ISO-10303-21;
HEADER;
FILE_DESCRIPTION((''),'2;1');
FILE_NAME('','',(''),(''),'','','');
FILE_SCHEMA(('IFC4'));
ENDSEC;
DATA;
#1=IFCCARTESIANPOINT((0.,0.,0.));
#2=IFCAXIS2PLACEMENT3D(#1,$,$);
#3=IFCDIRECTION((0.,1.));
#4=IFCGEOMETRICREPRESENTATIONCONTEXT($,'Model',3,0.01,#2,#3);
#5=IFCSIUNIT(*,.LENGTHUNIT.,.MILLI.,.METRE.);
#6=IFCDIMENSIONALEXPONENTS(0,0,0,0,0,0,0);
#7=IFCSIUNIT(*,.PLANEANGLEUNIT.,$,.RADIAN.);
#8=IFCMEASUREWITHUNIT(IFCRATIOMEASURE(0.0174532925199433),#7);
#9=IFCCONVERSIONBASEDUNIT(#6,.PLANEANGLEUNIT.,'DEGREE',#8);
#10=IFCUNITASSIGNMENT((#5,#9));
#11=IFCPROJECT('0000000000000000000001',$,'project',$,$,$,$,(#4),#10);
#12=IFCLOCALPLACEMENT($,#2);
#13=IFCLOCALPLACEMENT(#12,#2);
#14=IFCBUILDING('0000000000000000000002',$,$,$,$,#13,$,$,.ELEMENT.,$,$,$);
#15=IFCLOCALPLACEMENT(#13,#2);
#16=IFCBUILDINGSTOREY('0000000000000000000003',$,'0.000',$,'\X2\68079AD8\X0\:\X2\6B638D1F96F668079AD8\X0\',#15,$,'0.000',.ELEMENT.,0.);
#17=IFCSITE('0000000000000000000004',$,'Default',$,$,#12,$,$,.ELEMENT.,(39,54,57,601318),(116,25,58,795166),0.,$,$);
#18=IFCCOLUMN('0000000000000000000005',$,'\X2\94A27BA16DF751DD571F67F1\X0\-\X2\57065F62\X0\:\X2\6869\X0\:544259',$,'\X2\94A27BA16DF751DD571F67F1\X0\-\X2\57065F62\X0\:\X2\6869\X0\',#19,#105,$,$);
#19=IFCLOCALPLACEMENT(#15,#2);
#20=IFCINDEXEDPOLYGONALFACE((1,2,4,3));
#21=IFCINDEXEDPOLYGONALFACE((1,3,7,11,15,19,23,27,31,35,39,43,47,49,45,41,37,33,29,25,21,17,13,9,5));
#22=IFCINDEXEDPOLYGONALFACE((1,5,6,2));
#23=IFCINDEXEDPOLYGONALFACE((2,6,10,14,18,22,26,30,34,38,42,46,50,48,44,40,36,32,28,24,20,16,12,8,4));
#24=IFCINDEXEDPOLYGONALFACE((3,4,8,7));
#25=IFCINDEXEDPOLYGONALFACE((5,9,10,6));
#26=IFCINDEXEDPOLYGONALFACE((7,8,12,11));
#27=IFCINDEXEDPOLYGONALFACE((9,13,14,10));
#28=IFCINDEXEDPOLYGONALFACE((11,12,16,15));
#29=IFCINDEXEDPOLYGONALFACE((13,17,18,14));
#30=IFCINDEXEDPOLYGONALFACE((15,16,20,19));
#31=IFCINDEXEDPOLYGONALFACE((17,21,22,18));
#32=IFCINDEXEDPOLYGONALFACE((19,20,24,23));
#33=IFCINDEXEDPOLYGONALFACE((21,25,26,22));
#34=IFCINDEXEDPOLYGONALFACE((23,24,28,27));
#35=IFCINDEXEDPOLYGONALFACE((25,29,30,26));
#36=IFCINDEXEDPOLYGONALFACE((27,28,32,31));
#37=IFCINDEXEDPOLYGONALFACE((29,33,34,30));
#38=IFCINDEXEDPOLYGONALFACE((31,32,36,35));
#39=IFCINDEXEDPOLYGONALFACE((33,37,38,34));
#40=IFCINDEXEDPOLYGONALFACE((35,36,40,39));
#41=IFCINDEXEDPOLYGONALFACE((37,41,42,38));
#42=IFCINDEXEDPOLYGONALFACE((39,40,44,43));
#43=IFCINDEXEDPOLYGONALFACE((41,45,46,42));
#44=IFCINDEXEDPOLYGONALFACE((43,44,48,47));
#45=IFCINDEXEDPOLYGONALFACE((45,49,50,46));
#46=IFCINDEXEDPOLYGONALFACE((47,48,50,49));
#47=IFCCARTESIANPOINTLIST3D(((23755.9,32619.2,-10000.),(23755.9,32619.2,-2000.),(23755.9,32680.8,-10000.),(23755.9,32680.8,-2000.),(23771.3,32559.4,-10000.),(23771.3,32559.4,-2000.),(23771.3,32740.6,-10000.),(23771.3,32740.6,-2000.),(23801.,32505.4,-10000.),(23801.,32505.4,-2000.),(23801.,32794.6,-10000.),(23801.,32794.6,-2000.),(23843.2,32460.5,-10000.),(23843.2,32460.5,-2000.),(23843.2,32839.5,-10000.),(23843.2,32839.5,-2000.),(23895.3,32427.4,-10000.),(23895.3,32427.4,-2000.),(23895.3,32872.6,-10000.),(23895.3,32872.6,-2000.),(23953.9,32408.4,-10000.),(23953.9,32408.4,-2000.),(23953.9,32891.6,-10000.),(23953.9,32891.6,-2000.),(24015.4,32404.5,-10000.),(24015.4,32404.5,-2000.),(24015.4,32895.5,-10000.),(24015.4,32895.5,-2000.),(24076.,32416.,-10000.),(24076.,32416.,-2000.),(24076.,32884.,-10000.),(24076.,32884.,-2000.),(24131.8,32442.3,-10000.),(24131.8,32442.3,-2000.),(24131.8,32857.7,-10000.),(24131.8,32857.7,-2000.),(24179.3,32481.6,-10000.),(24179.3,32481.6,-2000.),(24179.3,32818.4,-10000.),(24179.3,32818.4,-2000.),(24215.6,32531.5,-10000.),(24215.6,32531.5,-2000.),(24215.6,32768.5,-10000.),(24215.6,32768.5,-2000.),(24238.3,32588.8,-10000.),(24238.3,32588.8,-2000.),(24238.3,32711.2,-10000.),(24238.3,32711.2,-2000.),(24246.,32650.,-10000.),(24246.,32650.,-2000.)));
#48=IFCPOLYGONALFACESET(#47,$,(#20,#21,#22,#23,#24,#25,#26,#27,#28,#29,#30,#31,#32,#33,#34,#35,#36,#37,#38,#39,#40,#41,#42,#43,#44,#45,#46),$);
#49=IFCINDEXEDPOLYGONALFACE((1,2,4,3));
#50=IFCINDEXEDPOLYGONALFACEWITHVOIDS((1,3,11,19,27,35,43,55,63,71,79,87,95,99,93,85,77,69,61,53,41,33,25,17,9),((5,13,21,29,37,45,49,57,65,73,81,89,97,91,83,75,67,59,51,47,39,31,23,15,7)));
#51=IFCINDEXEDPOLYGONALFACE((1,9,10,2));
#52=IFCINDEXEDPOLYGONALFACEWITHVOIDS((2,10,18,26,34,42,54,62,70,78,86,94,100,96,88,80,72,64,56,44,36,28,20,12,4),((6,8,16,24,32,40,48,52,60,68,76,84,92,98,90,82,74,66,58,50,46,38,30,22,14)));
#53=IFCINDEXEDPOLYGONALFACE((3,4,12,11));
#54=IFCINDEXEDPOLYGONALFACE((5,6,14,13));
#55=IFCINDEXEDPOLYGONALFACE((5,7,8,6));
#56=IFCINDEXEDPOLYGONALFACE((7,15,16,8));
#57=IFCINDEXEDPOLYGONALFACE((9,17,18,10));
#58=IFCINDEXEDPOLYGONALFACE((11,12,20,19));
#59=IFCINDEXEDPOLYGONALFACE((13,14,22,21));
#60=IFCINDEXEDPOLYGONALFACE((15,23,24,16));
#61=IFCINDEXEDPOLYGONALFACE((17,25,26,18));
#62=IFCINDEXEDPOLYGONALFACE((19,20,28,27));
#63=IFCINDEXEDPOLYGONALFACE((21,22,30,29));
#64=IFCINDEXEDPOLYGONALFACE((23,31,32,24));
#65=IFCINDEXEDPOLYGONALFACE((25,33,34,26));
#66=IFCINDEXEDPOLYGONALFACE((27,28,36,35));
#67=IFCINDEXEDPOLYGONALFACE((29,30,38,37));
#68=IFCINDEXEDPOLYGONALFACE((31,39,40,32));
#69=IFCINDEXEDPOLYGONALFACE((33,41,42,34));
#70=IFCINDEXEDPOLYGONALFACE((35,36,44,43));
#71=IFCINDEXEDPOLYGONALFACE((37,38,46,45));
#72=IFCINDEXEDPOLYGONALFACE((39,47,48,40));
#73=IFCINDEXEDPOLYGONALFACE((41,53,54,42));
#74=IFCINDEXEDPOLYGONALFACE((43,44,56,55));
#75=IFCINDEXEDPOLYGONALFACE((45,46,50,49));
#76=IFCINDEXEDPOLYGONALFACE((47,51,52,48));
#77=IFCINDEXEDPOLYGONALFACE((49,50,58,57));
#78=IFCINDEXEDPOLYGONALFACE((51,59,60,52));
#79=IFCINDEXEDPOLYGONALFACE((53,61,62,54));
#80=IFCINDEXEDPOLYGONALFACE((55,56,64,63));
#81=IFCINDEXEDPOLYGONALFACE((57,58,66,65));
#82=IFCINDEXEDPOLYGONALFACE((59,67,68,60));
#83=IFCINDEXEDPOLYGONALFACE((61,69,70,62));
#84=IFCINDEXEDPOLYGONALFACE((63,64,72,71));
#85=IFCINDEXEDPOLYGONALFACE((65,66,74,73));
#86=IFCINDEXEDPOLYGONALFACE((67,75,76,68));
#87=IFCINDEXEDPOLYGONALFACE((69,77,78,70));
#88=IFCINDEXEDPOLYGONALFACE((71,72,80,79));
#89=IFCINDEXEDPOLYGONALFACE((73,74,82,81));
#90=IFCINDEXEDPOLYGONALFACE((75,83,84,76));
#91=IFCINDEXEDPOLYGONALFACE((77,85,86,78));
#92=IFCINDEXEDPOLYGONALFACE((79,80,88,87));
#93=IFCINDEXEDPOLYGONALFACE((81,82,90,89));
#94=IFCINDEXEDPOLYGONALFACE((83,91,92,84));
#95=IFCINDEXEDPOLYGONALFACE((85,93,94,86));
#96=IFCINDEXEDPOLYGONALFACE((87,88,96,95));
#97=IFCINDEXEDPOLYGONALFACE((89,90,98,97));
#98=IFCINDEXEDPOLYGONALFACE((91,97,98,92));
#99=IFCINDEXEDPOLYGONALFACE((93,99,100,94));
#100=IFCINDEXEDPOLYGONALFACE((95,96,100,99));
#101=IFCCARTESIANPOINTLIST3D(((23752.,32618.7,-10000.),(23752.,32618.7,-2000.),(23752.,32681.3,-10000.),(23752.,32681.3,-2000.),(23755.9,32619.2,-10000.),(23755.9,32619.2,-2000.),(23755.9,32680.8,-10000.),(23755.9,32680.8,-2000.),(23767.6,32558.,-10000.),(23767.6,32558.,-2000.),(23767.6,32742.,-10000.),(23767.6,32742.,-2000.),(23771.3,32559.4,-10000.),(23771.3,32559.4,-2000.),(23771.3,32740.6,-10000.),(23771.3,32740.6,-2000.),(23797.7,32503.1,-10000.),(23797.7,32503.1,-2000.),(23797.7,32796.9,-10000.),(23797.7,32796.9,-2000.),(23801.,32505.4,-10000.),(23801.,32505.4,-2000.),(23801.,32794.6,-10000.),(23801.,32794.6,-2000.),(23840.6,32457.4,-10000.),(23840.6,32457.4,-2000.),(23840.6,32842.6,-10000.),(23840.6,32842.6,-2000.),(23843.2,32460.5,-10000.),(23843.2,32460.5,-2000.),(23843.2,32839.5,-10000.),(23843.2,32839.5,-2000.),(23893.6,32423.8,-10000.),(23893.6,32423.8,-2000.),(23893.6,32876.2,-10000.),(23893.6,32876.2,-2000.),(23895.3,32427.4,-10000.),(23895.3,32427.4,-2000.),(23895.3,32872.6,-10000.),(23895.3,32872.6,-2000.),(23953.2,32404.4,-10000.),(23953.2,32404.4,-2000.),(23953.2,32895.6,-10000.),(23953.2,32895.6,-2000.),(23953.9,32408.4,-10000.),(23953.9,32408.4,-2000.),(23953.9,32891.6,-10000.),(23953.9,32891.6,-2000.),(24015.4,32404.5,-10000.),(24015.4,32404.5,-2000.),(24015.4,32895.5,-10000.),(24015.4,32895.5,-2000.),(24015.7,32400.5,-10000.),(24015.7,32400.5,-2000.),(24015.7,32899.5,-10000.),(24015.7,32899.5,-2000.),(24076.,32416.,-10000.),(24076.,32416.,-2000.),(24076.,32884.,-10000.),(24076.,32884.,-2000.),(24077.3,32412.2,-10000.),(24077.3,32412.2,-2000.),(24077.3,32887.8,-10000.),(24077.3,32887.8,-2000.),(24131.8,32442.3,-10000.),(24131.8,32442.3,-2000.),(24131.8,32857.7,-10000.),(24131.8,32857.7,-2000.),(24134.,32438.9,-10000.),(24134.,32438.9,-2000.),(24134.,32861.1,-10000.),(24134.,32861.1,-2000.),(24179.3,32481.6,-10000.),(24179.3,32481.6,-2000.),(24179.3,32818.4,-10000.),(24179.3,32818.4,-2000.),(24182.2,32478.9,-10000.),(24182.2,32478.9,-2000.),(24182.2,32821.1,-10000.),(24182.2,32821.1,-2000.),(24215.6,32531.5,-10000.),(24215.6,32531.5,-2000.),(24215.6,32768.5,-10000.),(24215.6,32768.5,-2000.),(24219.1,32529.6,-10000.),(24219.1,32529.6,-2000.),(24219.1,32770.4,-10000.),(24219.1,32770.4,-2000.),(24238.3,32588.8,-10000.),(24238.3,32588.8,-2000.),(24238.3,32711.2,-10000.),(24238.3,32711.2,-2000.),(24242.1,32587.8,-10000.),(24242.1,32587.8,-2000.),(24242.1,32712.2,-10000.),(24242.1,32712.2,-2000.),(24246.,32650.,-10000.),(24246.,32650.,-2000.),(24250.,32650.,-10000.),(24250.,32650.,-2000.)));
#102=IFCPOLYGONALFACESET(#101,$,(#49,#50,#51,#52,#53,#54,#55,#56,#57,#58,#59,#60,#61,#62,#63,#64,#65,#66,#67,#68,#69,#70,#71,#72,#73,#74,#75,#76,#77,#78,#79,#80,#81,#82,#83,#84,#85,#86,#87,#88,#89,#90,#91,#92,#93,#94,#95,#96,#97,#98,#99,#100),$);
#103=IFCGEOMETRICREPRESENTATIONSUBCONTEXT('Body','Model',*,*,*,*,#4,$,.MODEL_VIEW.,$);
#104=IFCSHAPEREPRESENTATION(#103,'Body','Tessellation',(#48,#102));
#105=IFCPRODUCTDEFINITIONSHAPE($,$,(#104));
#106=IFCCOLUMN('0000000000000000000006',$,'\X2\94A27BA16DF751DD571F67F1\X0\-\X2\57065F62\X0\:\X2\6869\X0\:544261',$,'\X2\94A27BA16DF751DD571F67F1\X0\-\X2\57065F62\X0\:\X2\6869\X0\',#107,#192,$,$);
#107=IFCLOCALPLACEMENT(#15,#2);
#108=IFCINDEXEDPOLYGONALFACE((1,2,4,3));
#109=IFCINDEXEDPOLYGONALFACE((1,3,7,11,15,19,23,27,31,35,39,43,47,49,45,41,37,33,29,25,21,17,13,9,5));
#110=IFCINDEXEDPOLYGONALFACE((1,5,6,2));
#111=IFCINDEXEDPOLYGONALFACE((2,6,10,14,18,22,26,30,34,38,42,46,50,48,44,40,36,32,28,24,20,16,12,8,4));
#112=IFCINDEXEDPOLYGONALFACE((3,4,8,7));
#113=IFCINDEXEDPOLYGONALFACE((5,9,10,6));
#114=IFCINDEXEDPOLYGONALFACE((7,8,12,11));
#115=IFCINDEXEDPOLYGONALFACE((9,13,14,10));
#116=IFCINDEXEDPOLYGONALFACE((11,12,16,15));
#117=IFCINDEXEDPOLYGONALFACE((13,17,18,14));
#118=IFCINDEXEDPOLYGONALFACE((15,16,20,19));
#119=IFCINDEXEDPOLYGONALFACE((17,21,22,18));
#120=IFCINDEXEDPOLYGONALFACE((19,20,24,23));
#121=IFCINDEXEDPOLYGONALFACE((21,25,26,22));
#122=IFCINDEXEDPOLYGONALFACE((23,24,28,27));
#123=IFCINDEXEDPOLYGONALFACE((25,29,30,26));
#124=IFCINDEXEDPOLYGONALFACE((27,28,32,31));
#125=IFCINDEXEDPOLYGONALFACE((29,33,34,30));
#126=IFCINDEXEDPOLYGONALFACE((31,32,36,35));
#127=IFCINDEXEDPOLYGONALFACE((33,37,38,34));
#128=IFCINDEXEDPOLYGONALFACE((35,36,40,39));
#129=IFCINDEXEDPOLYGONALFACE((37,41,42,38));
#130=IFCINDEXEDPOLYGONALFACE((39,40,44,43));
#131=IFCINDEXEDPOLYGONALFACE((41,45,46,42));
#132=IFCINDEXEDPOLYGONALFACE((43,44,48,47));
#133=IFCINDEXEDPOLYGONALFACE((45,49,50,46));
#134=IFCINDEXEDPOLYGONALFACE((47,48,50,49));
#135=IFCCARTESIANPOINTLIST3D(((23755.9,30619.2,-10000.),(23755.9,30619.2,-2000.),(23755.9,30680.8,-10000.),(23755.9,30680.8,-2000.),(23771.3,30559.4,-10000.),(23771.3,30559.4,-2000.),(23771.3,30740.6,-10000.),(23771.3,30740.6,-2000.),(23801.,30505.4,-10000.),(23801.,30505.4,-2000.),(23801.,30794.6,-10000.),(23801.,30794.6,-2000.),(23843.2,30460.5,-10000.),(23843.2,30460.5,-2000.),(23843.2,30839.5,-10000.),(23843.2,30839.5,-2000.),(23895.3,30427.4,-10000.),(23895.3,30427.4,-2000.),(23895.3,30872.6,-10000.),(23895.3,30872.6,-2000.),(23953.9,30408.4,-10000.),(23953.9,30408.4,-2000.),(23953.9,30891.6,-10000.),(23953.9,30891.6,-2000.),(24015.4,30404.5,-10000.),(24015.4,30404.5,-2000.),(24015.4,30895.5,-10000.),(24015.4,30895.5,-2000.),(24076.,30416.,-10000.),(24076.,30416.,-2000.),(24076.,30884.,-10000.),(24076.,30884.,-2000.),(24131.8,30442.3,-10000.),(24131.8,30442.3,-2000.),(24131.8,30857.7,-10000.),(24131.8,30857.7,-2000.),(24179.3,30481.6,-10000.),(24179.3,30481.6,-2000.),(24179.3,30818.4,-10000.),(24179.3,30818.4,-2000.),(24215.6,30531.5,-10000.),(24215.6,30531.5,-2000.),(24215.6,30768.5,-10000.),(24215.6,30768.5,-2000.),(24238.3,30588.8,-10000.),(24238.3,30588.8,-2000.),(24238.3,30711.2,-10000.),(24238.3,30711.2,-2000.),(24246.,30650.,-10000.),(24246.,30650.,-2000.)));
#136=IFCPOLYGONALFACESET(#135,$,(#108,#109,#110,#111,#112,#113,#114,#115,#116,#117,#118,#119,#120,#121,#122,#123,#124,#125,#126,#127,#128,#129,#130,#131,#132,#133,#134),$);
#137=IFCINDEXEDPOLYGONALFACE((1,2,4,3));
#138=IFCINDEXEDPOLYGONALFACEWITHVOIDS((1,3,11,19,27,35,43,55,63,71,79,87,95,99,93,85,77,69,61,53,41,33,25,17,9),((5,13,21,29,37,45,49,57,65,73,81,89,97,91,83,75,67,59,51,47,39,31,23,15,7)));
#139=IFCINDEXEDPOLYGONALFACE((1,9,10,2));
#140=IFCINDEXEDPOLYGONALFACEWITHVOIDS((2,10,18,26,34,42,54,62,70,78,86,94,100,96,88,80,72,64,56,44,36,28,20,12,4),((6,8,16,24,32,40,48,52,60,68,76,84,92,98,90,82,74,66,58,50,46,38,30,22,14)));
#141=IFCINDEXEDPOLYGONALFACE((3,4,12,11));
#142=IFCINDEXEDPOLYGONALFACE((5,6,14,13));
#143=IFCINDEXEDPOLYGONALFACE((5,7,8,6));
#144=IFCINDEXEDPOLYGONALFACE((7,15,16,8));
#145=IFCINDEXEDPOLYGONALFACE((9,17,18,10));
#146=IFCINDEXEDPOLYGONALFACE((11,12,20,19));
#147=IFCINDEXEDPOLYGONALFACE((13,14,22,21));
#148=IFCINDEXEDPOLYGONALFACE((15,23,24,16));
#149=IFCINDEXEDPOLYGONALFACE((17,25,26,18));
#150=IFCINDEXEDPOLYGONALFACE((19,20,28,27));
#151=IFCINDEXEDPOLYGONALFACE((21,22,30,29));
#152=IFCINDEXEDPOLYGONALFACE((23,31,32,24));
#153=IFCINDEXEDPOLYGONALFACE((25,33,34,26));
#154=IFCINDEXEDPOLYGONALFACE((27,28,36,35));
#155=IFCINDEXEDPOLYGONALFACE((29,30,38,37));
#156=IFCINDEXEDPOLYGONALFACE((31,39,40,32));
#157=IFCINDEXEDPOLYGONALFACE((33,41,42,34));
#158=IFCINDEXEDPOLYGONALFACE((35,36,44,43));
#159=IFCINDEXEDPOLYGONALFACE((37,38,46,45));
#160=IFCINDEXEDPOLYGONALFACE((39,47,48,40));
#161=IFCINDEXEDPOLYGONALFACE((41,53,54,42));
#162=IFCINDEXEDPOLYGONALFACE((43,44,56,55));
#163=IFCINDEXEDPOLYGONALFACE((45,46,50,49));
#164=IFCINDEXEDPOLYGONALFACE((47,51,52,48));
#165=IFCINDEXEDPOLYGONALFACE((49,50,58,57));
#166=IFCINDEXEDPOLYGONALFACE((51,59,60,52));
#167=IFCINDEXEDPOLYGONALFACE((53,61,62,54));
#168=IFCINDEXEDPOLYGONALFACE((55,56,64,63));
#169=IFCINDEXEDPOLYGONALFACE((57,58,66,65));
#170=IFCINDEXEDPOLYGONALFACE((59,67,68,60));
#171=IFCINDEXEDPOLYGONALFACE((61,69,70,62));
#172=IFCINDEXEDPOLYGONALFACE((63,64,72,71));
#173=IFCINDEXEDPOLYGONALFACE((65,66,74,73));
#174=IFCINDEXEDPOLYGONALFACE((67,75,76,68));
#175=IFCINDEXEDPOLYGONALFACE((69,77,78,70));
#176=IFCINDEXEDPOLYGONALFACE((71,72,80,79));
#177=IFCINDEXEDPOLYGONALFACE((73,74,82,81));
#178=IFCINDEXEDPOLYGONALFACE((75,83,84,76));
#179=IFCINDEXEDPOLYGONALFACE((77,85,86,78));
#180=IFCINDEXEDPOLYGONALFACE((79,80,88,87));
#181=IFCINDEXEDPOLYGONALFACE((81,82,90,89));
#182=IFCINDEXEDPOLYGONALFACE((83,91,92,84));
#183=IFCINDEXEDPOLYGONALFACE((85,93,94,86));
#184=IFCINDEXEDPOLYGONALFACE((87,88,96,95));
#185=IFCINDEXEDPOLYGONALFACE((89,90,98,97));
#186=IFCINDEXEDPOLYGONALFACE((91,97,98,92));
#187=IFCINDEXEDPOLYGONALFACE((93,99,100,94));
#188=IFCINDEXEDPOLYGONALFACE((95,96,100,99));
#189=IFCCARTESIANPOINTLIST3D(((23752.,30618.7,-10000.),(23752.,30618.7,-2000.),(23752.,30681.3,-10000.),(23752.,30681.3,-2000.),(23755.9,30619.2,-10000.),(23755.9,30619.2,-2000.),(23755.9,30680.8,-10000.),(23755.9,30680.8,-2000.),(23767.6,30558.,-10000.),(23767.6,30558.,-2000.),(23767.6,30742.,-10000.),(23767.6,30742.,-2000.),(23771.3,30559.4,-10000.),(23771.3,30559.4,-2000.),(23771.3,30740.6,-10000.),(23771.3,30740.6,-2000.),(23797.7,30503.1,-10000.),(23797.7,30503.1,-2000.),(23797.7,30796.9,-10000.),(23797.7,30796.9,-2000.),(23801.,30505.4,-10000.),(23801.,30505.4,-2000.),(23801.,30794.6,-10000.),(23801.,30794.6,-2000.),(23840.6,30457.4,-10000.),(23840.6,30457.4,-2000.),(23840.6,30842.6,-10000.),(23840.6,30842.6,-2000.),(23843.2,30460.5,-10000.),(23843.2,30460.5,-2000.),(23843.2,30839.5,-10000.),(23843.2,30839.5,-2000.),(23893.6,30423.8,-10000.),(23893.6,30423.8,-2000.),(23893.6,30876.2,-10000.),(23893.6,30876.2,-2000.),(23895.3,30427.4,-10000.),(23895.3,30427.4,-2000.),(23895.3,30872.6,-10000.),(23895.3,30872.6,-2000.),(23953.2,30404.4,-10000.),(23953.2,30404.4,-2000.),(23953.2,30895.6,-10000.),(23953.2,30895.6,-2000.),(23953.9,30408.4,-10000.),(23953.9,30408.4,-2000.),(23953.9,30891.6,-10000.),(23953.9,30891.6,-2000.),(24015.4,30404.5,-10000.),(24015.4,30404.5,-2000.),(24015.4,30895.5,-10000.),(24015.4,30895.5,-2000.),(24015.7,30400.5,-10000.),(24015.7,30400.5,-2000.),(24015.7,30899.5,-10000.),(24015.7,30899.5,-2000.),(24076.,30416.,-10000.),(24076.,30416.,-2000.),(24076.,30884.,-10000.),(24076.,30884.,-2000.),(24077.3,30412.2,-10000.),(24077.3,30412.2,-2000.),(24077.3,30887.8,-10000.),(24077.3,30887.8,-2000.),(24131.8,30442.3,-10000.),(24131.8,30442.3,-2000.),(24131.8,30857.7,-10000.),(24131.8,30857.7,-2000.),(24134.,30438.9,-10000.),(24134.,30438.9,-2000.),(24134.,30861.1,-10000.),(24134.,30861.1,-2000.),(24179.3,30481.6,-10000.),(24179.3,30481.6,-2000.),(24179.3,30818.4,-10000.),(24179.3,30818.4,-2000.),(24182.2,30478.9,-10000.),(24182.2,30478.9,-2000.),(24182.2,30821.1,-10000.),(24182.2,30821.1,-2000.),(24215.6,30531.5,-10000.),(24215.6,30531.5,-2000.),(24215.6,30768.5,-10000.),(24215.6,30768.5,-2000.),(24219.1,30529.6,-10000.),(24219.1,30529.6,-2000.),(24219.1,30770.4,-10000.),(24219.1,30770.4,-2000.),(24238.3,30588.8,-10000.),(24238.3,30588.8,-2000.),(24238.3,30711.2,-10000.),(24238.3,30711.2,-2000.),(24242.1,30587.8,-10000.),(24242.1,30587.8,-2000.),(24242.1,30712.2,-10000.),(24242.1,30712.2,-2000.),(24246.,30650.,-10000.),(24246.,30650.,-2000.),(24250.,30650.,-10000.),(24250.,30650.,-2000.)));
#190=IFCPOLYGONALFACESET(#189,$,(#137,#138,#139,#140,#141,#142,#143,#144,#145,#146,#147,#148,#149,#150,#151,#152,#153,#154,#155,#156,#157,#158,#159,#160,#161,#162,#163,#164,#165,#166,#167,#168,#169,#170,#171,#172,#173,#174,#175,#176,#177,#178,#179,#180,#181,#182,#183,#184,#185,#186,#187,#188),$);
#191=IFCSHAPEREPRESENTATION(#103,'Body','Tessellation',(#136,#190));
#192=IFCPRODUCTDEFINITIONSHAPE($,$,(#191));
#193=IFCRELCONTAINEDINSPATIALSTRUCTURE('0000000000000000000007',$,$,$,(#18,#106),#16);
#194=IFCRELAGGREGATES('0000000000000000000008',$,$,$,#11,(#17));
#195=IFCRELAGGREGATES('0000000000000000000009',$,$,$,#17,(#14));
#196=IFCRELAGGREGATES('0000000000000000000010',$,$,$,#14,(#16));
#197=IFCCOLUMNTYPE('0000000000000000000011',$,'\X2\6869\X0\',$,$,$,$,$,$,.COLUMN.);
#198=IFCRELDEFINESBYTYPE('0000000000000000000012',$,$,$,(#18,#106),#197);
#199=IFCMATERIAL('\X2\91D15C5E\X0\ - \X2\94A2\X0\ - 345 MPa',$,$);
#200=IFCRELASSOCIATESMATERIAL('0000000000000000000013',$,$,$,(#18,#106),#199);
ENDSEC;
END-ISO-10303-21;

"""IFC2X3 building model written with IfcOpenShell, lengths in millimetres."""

from ifc_helpers import new_model, entity, si_unit, converted_unit, direction, frame, frame_2d, origin, place, context, subcontext, project, spatial, circle, hollow_circle, extrude, source, transform, mapped, material, type_object, type_shapes, element, save


model = new_model("IFC2X3")

# Units and contexts
model_context = context("Model", 3, precision=0.01, world=origin(), true_north=direction((0.0, 1.0)))
body_context = subcontext(model_context, "Body", "Model", "MODEL_VIEW")
ifc_project = project(units=[si_unit("LENGTHUNIT", "METRE", prefix="MILLI"), converted_unit("PLANEANGLEUNIT", "DEGREE", entity("IfcRatioMeasure", 0.0174532925199433), si_unit("PLANEANGLEUNIT", "RADIAN"), dimensions=[0, 0, 0, 0, 0, 0, 0])], contexts=[model_context])

# Site, building, storey
site_placement = place(None, origin())
site = spatial("IfcSite", under=ifc_project, at=site_placement, Name="Default", CompositionType="ELEMENT", RefLatitude=(39, 54, 57, 601318), RefLongitude=(116, 25, 58, 795166), RefElevation=0.0)
building_placement = place(site_placement, origin())
building = spatial("IfcBuilding", under=site, at=building_placement, CompositionType="ELEMENT")
storey_placement = place(building_placement, origin())
storey = spatial("IfcBuildingStorey", under=building, at=storey_placement, Name="0.000", ObjectType="标高:正负零标高", LongName="0.000", CompositionType="ELEMENT", Elevation=0.0)

# Columns
ifc_material_1 = material(Name="金属 - 钢 - 345 MPa")
column_type_1 = type_object("IfcColumnType", Name="桩", PredefinedType="COLUMN")
shared_shape_1 = source(origin(), body_context, "Body", "SweptSolid", [
    extrude(circle(Radius=246.0, at=frame_2d((0.0, 0.0), x_axis=(1.0, 0.0))), frame((0.0, 0.0, -10000.0)), (0.0, 0.0, 1.0), 8000.0),
    extrude(hollow_circle(Radius=250.0, WallThickness=4.0, at=frame_2d((0.0, 0.0), x_axis=(1.0, 0.0))), frame((0.0, 0.0, -10000.0)), (0.0, 0.0, 1.0), 8000.0),
])
type_shapes(column_type_1, [shared_shape_1])
for number, where, name in (
    (1, (24000.0, 32650.0, 0.0), "钢管混凝土柱-圆形:桩:544259"),
    (2, (24000.0, 30650.0, 0.0), "钢管混凝土柱-圆形:桩:544261"),
):
    element("IfcColumn", number, at=place(storey_placement, frame(where)), inside=storey, type_object=column_type_1, material=ifc_material_1, Name=name, ObjectType="钢管混凝土柱-圆形:桩", context=body_context, shape_type="MappedRepresentation", body=[
        mapped(shared_shape_1, transform((0.0, 0.0, 0.0), scale=1.0)),
    ])

save(model, "model.ifc")
